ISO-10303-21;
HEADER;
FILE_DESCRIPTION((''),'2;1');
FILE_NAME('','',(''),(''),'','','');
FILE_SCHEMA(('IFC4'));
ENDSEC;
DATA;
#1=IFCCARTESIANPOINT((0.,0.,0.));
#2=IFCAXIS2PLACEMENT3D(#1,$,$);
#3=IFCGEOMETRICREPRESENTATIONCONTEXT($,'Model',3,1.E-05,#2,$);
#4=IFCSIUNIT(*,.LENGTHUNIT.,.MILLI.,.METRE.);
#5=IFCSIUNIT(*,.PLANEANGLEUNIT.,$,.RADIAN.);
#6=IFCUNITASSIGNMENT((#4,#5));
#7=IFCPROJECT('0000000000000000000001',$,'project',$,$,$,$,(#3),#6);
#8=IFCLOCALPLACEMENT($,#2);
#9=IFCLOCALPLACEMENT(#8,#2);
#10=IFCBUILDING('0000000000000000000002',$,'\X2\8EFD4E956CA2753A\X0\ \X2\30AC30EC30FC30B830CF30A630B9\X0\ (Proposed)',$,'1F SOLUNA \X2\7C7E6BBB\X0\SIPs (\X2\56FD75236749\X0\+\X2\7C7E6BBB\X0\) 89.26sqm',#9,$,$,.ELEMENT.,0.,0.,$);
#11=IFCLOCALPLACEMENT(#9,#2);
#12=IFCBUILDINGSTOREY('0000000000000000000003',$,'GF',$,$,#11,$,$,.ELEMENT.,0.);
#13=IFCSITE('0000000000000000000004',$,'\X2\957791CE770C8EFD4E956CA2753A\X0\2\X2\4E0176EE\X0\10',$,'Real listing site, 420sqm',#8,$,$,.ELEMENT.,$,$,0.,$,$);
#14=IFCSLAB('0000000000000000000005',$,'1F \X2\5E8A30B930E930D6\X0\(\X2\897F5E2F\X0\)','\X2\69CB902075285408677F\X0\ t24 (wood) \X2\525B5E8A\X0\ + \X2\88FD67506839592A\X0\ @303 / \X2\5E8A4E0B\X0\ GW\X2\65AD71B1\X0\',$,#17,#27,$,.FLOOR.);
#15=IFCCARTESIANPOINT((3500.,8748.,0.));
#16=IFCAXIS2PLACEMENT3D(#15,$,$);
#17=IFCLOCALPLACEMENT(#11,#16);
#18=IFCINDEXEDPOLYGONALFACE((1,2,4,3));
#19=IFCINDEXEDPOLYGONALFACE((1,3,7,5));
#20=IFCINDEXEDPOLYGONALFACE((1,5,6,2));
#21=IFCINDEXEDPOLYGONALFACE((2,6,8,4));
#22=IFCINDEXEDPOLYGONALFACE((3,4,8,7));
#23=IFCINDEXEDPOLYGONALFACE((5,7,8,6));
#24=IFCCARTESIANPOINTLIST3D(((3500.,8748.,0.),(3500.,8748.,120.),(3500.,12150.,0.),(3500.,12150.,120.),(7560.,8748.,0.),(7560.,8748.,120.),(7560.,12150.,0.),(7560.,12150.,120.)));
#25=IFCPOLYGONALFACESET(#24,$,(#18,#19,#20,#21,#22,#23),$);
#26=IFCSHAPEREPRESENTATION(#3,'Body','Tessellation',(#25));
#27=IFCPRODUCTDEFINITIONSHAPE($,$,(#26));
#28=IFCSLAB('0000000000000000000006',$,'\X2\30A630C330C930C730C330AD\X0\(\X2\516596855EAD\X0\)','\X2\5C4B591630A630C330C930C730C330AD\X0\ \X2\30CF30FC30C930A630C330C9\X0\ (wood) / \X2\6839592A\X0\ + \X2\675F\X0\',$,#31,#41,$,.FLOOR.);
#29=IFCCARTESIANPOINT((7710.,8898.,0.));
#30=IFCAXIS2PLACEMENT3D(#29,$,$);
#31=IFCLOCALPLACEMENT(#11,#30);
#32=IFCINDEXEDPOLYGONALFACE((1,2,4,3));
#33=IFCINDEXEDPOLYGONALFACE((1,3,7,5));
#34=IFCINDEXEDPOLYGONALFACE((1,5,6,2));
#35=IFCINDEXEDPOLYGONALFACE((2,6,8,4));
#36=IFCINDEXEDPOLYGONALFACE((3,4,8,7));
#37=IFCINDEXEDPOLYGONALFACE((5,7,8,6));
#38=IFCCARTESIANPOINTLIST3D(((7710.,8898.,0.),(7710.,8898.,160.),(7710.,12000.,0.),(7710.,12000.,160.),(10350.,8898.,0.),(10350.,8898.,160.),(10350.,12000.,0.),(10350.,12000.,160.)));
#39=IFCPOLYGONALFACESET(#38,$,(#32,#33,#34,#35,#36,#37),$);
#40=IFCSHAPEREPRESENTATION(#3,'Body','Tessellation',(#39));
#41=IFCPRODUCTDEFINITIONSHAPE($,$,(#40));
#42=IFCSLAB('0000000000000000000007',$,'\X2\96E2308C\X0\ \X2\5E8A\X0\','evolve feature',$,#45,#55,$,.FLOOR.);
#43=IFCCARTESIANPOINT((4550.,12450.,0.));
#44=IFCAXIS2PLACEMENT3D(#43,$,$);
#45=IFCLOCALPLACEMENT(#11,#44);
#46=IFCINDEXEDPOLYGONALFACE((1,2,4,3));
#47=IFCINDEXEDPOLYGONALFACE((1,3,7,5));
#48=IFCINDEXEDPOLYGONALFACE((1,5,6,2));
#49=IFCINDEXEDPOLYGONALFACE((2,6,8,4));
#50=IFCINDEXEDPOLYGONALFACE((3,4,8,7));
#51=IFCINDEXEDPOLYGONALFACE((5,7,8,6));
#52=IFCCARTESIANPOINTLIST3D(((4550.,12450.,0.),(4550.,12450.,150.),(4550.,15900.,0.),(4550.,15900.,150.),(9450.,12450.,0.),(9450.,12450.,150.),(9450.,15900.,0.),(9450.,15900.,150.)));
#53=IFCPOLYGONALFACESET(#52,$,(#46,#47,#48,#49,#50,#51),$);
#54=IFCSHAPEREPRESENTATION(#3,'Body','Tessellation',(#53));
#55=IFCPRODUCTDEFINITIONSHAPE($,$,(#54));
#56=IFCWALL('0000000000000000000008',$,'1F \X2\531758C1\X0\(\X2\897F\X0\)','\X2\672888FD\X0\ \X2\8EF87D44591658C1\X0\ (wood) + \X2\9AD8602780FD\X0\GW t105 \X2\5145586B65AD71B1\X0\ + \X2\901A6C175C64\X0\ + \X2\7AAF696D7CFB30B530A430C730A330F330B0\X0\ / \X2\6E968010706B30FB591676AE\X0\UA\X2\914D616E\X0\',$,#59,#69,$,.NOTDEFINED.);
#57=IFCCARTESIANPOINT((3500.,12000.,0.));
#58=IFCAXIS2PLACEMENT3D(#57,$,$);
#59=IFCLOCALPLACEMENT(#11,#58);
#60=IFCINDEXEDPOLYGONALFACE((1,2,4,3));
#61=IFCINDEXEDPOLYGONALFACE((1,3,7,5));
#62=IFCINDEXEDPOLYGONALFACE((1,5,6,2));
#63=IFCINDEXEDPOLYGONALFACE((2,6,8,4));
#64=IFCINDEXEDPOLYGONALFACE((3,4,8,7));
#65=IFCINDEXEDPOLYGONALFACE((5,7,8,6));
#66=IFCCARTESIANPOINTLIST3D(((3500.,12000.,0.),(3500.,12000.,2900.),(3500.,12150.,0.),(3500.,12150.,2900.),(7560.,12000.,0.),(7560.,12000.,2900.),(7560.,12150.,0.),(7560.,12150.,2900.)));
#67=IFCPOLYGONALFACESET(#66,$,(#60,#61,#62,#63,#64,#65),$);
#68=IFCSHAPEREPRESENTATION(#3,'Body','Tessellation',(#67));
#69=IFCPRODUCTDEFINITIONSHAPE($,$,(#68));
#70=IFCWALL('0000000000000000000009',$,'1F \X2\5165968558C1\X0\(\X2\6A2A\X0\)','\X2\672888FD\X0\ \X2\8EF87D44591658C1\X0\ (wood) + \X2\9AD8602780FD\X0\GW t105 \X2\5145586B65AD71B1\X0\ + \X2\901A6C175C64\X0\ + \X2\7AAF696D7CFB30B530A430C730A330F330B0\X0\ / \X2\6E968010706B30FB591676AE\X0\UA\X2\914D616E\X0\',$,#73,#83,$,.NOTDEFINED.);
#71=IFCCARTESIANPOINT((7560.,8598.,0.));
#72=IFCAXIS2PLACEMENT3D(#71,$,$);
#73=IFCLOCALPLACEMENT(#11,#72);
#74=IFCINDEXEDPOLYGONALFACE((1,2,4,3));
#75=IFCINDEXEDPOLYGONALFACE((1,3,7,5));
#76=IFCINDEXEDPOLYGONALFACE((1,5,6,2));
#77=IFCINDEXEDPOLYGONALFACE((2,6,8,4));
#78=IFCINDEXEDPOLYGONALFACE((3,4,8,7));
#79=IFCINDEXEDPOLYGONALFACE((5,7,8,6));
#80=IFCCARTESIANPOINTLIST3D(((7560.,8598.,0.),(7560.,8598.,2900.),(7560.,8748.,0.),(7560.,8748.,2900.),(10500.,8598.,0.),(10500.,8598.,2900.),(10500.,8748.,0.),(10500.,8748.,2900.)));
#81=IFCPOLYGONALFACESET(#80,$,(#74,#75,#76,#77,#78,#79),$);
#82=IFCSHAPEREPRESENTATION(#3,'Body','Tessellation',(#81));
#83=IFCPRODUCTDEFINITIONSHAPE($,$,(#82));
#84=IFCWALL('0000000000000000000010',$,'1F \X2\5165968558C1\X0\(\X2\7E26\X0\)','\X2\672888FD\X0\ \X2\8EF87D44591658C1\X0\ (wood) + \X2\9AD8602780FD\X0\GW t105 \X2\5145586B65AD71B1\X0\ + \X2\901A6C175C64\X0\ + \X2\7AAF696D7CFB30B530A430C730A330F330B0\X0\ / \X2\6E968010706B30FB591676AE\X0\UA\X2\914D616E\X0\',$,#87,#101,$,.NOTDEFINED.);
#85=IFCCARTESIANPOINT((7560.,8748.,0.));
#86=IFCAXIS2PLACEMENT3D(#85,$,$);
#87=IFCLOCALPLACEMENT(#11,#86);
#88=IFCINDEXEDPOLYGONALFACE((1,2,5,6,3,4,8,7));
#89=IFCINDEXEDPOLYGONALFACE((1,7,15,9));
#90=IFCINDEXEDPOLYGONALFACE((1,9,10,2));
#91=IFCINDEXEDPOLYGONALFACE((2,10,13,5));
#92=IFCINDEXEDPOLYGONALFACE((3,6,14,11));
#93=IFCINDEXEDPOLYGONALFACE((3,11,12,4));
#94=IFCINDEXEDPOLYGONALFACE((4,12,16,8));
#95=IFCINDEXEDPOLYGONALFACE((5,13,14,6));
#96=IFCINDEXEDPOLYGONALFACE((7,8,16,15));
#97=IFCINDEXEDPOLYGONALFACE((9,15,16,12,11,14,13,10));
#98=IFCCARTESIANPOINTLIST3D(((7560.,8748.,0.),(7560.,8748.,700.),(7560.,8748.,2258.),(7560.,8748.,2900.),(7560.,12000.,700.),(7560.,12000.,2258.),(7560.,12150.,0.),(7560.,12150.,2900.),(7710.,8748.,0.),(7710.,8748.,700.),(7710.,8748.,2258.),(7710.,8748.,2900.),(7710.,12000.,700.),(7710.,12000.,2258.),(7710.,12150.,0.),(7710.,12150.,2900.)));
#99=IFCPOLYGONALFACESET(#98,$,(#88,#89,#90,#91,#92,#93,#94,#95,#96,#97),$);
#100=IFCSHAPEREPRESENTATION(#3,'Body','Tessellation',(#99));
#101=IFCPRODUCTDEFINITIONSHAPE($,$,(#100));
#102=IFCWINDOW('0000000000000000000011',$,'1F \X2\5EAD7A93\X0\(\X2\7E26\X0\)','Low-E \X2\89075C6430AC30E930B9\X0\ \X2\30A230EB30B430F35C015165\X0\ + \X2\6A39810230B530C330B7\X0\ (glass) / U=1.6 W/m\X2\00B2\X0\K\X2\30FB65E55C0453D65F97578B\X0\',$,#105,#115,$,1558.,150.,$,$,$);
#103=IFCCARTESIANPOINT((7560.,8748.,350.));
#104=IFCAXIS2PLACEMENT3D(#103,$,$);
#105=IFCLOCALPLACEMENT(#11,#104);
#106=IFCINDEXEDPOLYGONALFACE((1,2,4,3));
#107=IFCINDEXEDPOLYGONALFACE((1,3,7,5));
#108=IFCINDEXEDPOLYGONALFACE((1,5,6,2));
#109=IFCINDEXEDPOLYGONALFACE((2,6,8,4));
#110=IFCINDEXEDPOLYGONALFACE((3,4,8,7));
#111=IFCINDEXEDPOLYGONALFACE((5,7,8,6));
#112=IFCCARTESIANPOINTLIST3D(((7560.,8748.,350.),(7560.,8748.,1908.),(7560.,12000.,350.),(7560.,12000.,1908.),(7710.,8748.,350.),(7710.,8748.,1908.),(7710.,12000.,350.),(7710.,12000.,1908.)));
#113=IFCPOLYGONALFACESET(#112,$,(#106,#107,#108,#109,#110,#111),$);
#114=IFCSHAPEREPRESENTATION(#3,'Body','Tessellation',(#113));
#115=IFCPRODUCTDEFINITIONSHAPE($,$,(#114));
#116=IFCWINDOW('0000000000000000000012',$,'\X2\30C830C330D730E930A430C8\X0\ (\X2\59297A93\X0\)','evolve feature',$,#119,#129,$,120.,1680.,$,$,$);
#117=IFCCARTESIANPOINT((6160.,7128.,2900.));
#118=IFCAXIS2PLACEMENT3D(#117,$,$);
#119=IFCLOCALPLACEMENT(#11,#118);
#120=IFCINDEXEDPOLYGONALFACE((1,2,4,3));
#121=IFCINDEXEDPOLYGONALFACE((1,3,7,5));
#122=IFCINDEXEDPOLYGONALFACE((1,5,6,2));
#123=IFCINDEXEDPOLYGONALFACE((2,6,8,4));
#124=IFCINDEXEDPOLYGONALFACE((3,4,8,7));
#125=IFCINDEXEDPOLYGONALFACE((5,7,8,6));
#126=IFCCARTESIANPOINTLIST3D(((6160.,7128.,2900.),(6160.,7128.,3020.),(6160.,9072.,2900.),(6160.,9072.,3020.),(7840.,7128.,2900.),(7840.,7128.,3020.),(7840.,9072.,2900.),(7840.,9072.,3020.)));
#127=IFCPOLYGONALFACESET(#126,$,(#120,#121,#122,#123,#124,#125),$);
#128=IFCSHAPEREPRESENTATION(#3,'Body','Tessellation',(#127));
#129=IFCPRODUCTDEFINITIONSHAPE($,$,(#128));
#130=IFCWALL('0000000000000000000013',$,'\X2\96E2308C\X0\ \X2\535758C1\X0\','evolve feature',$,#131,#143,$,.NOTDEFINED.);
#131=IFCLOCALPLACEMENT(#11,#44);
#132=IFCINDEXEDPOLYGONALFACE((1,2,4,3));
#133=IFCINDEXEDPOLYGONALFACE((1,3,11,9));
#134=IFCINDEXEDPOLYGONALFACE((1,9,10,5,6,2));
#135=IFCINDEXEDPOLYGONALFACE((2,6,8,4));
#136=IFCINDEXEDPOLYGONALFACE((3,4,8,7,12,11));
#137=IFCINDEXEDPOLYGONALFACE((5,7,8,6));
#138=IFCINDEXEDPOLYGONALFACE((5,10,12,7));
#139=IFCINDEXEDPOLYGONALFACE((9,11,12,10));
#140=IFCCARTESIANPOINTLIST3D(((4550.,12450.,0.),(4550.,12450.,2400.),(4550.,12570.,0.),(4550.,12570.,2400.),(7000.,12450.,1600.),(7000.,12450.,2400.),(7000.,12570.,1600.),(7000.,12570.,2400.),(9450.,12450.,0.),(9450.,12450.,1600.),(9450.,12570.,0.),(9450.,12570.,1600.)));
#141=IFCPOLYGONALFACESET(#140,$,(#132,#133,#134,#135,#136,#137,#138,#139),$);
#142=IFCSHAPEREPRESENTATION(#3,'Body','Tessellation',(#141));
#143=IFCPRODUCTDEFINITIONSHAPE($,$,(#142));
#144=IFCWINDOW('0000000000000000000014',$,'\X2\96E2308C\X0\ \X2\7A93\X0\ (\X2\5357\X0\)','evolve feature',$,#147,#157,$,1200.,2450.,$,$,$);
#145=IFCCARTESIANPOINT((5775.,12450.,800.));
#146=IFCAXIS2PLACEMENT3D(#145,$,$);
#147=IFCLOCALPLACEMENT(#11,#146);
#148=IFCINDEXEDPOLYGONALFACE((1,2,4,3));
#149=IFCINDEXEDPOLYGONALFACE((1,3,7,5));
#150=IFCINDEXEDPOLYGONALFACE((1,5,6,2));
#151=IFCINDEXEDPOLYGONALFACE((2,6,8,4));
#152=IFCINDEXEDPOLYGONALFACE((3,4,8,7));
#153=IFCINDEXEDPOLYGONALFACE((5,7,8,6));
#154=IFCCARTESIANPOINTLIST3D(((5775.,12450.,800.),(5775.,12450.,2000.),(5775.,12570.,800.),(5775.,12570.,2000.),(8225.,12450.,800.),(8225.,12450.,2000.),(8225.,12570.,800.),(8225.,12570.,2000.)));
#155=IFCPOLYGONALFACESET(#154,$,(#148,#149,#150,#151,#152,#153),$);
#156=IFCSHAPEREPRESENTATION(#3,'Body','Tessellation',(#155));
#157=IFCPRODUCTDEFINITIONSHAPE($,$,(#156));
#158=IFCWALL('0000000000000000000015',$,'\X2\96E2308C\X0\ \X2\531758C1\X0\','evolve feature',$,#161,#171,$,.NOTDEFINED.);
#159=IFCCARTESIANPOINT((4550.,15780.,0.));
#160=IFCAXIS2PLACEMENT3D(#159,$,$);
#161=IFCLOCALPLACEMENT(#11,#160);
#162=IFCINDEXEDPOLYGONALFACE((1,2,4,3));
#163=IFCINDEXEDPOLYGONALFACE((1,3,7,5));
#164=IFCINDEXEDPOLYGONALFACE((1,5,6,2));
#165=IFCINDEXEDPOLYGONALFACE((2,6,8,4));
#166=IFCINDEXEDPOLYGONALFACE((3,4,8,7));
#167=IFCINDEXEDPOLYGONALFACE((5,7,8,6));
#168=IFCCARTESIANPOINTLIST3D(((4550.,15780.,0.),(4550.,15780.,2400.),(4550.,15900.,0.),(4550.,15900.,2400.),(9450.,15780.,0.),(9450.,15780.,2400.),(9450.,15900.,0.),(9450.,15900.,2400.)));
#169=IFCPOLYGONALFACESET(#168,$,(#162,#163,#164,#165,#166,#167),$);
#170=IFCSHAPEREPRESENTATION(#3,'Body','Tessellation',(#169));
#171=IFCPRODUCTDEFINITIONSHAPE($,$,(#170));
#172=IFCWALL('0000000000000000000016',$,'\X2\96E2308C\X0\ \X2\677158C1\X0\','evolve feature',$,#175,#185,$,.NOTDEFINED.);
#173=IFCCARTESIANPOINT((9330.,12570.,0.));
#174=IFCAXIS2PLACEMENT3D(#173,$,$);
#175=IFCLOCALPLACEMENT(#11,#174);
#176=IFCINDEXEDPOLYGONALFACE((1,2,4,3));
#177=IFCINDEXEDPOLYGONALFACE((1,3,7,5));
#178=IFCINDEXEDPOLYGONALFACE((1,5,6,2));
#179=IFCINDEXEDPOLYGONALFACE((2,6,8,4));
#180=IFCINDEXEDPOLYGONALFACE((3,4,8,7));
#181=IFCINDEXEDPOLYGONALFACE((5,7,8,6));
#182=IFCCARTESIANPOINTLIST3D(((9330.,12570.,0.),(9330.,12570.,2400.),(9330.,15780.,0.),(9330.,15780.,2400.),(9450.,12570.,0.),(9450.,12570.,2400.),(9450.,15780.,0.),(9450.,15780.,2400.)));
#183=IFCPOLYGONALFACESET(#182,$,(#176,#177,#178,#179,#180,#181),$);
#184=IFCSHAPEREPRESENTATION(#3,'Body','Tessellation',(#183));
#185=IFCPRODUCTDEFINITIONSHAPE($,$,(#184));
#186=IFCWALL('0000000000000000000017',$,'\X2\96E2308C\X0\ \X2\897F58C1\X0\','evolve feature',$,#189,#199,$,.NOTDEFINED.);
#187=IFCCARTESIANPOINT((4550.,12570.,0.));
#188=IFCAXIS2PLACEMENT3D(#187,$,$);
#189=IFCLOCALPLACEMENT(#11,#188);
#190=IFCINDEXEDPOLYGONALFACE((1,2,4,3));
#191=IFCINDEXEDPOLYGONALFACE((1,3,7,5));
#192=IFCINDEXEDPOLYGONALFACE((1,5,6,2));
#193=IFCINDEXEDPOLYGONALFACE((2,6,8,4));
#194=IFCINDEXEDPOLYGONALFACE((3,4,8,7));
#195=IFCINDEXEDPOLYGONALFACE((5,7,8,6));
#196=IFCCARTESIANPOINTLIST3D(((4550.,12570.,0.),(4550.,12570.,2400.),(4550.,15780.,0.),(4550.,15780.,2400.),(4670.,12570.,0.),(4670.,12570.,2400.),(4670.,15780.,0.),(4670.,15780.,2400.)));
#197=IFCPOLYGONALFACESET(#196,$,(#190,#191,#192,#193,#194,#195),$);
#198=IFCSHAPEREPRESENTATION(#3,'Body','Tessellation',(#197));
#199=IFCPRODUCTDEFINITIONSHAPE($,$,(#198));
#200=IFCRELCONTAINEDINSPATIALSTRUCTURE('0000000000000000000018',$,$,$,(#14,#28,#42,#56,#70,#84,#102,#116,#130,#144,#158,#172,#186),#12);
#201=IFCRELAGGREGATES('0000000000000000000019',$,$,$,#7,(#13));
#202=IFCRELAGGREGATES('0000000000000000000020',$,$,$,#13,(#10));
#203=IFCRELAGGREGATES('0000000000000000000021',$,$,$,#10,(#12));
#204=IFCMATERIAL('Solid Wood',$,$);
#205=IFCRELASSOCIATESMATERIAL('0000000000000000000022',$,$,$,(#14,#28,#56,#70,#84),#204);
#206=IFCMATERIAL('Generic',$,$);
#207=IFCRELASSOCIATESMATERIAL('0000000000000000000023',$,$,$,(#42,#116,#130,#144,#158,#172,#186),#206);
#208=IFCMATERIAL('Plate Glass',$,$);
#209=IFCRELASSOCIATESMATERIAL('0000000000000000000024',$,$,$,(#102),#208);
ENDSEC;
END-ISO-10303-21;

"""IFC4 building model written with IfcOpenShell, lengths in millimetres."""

from ifc_helpers import new_model, si_unit, frame, frame_2d, origin, place, context, project, spatial, rectangle, extrude, material, element, fill, save


model = new_model("IFC4")

# Units and contexts
model_context = context("Model", 3, precision=1e-05, world=origin())
ifc_project = project(units=[si_unit("LENGTHUNIT", "METRE", prefix="MILLI"), si_unit("PLANEANGLEUNIT", "RADIAN")], contexts=[model_context])

# Site, building, storey
site_placement = place(None, origin())
site = spatial("IfcSite", under=ifc_project, at=site_placement, Name="長野県軽井沢町2丁目10", ObjectType="Real listing site, 420sqm", CompositionType="ELEMENT", RefElevation=0.0)
building_placement = place(site_placement, origin())
building = spatial("IfcBuilding", under=site, at=building_placement, Name="軽井沢町 ガレージハウス (Proposed)", ObjectType="1F SOLUNA 籾殻SIPs (国産杉+籾殻) 89.26sqm", CompositionType="ELEMENT", ElevationOfRefHeight=0.0, ElevationOfTerrain=0.0)
storey_placement = place(building_placement, origin())
storey = spatial("IfcBuildingStorey", under=building, at=storey_placement, Name="GF", CompositionType="ELEMENT", Elevation=0.0)

# Slabs
ifc_material_1 = material(Name="Solid Wood")
slab_1_placement = place(storey_placement, frame((3500.0, 8748.0, 0.0)))
element("IfcSlab", 1, at=slab_1_placement, inside=storey, material=ifc_material_1, Name="1F 床スラブ(西帯)", Description="構造用合板 t24 (wood) 剛床 + 製材根太 @303 / 床下 GW断熱", PredefinedType="FLOOR", context=model_context, shape_type="SweptSolid", body=[
    extrude(rectangle(XDim=4060.0, YDim=3402.0, at=frame_2d((2030.0, 1701.0))), frame((3500.0, 8748.0, 0.0)), (0.0, 0.0, 1.0), 120.0),
])
slab_2_placement = place(storey_placement, frame((7710.0, 8898.0, 0.0)))
element("IfcSlab", 2, at=slab_2_placement, inside=storey, material=ifc_material_1, Name="ウッドデッキ(入隅庭)", Description="屋外ウッドデッキ ハードウッド (wood) / 根太 + 束", PredefinedType="FLOOR", context=model_context, shape_type="SweptSolid", body=[
    extrude(rectangle(XDim=2640.0, YDim=3102.0, at=frame_2d((1320.0, 1551.0))), frame((7710.0, 8898.0, 0.0)), (0.0, 0.0, 1.0), 160.0),
])
ifc_material_2 = material(Name="Generic")
slab_3_placement = place(storey_placement, frame((4550.0, 12450.0, 0.0)))
element("IfcSlab", 3, at=slab_3_placement, inside=storey, material=ifc_material_2, Name="離れ 床", Description="evolve feature", PredefinedType="FLOOR", context=model_context, shape_type="SweptSolid", body=[
    extrude(rectangle(XDim=4900.0, YDim=3450.0, at=frame_2d((2450.0, 1725.0))), frame((4550.0, 12450.0, 0.0)), (0.0, 0.0, 1.0), 150.0),
])

# Walls
wall_1_placement = place(storey_placement, frame((3500.0, 12000.0, 0.0)))
element("IfcWall", 4, at=wall_1_placement, inside=storey, material=ifc_material_1, Name="1F 北壁(西)", Description="木製 軸組外壁 (wood) + 高性能GW t105 充填断熱 + 通気層 + 窯業系サイディング / 準耐火・外皮UA配慮", PredefinedType="NOTDEFINED", context=model_context, shape_type="SweptSolid", body=[
    extrude(rectangle(XDim=4060.0, YDim=150.0, at=frame_2d((2030.0, 75.0))), frame((3500.0, 12000.0, 0.0)), (0.0, 0.0, 1.0), 2900.0),
])
wall_2_placement = place(storey_placement, frame((7560.0, 8598.0, 0.0)))
element("IfcWall", 5, at=wall_2_placement, inside=storey, material=ifc_material_1, Name="1F 入隅壁(横)", Description="木製 軸組外壁 (wood) + 高性能GW t105 充填断熱 + 通気層 + 窯業系サイディング / 準耐火・外皮UA配慮", PredefinedType="NOTDEFINED", context=model_context, shape_type="SweptSolid", body=[
    extrude(rectangle(XDim=2940.0, YDim=150.0, at=frame_2d((1470.0, 75.0))), frame((7560.0, 8598.0, 0.0)), (0.0, 0.0, 1.0), 2900.0),
])

# Wall, opening, window
wall_3_placement = place(storey_placement, frame((7560.0, 8748.0, 0.0)))
wall_3 = element("IfcWall", 6, at=wall_3_placement, inside=storey, material=ifc_material_1, Name="1F 入隅壁(縦)", Description="木製 軸組外壁 (wood) + 高性能GW t105 充填断熱 + 通気層 + 窯業系サイディング / 準耐火・外皮UA配慮", PredefinedType="NOTDEFINED", context=model_context, shape_type="SweptSolid", body=[
    extrude(rectangle(XDim=150.0, YDim=3402.0, at=frame_2d((75.0, 1701.0))), frame((7560.0, 8748.0, 0.0)), (0.0, 0.0, 1.0), 2900.0),
])
opening_1_placement = place(storey_placement, frame((7560.0, 8748.0, 350.0)))
opening_1 = element("IfcOpeningElement", 7, at=opening_1_placement, cuts=wall_3, PredefinedType="NOTDEFINED", context=model_context, shape_type="SweptSolid", body=[
    extrude(rectangle(XDim=150.0, YDim=3252.0, at=frame_2d((75.0, 1626.0))), frame((7560.0, 8748.0, 350.0)), (0.0, 0.0, 1.0), 1558.0),
])
ifc_material_3 = material(Name="Plate Glass")
window_1_placement = place(storey_placement, frame((7560.0, 8748.0, 350.0)))
window_1 = element("IfcWindow", 8, at=window_1_placement, inside=storey, material=ifc_material_3, Name="1F 庭窓(縦)", Description="Low-E 複層ガラス アルゴン封入 + 樹脂サッシ (glass) / U=1.6 W/m²K・日射取得型", OverallHeight=1558.0, OverallWidth=150.0, context=model_context, shape_type="SweptSolid", body=[
    extrude(rectangle(XDim=150.0, YDim=3252.0, at=frame_2d((75.0, 1626.0))), frame((7560.0, 8748.0, 350.0)), (0.0, 0.0, 1.0), 1558.0),
])
fill(opening_1, window_1)

# Window
window_2_placement = place(storey_placement, frame((6160.0, 7128.0, 2900.0)))
element("IfcWindow", 9, at=window_2_placement, inside=storey, material=ifc_material_2, Name="トップライト (天窓)", Description="evolve feature", OverallHeight=120.0, OverallWidth=1680.0, context=model_context, shape_type="SweptSolid", body=[
    extrude(rectangle(XDim=1680.0, YDim=1944.0, at=frame_2d((840.0, 972.0))), frame((6160.0, 7128.0, 2900.0)), (0.0, 0.0, 1.0), 120.0),
])

# Wall, opening, window
wall_4_placement = place(storey_placement, frame((4550.0, 12450.0, 0.0)))
wall_4 = element("IfcWall", 10, at=wall_4_placement, inside=storey, material=ifc_material_2, Name="離れ 南壁", Description="evolve feature", PredefinedType="NOTDEFINED", context=model_context, shape_type="SweptSolid", body=[
    extrude(rectangle(XDim=4900.0, YDim=120.0, at=frame_2d((2450.0, 60.0))), frame((4550.0, 12450.0, 0.0)), (0.0, 0.0, 1.0), 2400.0),
])
opening_2_placement = place(storey_placement, frame((5775.0, 12450.0, 800.0)))
opening_2 = element("IfcOpeningElement", 11, at=opening_2_placement, cuts=wall_4, PredefinedType="NOTDEFINED", context=model_context, shape_type="SweptSolid", body=[
    extrude(rectangle(XDim=2450.0, YDim=120.0, at=frame_2d((1225.0, 60.0))), frame((5775.0, 12450.0, 800.0)), (0.0, 0.0, 1.0), 1200.0),
])
window_3_placement = place(storey_placement, frame((5775.0, 12450.0, 800.0)))
window_3 = element("IfcWindow", 12, at=window_3_placement, inside=storey, material=ifc_material_2, Name="離れ 窓 (南)", Description="evolve feature", OverallHeight=1200.0, OverallWidth=2450.0, context=model_context, shape_type="SweptSolid", body=[
    extrude(rectangle(XDim=2450.0, YDim=120.0, at=frame_2d((1225.0, 60.0))), frame((5775.0, 12450.0, 800.0)), (0.0, 0.0, 1.0), 1200.0),
])
fill(opening_2, window_3)

# Walls
wall_5_placement = place(storey_placement, frame((4550.0, 15780.0, 0.0)))
element("IfcWall", 13, at=wall_5_placement, inside=storey, material=ifc_material_2, Name="離れ 北壁", Description="evolve feature", PredefinedType="NOTDEFINED", context=model_context, shape_type="SweptSolid", body=[
    extrude(rectangle(XDim=4900.0, YDim=120.0, at=frame_2d((2450.0, 60.0))), frame((4550.0, 15780.0, 0.0)), (0.0, 0.0, 1.0), 2400.0),
])
wall_6_placement = place(storey_placement, frame((9330.0, 12570.0, 0.0)))
element("IfcWall", 14, at=wall_6_placement, inside=storey, material=ifc_material_2, Name="離れ 東壁", Description="evolve feature", PredefinedType="NOTDEFINED", context=model_context, shape_type="SweptSolid", body=[
    extrude(rectangle(XDim=120.0, YDim=3210.0, at=frame_2d((60.0, 1605.0))), frame((9330.0, 12570.0, 0.0)), (0.0, 0.0, 1.0), 2400.0),
])
wall_7_placement = place(storey_placement, frame((4550.0, 12570.0, 0.0)))
element("IfcWall", 15, at=wall_7_placement, inside=storey, material=ifc_material_2, Name="離れ 西壁", Description="evolve feature", PredefinedType="NOTDEFINED", context=model_context, shape_type="SweptSolid", body=[
    extrude(rectangle(XDim=120.0, YDim=3210.0, at=frame_2d((60.0, 1605.0))), frame((4550.0, 12570.0, 0.0)), (0.0, 0.0, 1.0), 2400.0),
])

save(model, "model.ifc")
